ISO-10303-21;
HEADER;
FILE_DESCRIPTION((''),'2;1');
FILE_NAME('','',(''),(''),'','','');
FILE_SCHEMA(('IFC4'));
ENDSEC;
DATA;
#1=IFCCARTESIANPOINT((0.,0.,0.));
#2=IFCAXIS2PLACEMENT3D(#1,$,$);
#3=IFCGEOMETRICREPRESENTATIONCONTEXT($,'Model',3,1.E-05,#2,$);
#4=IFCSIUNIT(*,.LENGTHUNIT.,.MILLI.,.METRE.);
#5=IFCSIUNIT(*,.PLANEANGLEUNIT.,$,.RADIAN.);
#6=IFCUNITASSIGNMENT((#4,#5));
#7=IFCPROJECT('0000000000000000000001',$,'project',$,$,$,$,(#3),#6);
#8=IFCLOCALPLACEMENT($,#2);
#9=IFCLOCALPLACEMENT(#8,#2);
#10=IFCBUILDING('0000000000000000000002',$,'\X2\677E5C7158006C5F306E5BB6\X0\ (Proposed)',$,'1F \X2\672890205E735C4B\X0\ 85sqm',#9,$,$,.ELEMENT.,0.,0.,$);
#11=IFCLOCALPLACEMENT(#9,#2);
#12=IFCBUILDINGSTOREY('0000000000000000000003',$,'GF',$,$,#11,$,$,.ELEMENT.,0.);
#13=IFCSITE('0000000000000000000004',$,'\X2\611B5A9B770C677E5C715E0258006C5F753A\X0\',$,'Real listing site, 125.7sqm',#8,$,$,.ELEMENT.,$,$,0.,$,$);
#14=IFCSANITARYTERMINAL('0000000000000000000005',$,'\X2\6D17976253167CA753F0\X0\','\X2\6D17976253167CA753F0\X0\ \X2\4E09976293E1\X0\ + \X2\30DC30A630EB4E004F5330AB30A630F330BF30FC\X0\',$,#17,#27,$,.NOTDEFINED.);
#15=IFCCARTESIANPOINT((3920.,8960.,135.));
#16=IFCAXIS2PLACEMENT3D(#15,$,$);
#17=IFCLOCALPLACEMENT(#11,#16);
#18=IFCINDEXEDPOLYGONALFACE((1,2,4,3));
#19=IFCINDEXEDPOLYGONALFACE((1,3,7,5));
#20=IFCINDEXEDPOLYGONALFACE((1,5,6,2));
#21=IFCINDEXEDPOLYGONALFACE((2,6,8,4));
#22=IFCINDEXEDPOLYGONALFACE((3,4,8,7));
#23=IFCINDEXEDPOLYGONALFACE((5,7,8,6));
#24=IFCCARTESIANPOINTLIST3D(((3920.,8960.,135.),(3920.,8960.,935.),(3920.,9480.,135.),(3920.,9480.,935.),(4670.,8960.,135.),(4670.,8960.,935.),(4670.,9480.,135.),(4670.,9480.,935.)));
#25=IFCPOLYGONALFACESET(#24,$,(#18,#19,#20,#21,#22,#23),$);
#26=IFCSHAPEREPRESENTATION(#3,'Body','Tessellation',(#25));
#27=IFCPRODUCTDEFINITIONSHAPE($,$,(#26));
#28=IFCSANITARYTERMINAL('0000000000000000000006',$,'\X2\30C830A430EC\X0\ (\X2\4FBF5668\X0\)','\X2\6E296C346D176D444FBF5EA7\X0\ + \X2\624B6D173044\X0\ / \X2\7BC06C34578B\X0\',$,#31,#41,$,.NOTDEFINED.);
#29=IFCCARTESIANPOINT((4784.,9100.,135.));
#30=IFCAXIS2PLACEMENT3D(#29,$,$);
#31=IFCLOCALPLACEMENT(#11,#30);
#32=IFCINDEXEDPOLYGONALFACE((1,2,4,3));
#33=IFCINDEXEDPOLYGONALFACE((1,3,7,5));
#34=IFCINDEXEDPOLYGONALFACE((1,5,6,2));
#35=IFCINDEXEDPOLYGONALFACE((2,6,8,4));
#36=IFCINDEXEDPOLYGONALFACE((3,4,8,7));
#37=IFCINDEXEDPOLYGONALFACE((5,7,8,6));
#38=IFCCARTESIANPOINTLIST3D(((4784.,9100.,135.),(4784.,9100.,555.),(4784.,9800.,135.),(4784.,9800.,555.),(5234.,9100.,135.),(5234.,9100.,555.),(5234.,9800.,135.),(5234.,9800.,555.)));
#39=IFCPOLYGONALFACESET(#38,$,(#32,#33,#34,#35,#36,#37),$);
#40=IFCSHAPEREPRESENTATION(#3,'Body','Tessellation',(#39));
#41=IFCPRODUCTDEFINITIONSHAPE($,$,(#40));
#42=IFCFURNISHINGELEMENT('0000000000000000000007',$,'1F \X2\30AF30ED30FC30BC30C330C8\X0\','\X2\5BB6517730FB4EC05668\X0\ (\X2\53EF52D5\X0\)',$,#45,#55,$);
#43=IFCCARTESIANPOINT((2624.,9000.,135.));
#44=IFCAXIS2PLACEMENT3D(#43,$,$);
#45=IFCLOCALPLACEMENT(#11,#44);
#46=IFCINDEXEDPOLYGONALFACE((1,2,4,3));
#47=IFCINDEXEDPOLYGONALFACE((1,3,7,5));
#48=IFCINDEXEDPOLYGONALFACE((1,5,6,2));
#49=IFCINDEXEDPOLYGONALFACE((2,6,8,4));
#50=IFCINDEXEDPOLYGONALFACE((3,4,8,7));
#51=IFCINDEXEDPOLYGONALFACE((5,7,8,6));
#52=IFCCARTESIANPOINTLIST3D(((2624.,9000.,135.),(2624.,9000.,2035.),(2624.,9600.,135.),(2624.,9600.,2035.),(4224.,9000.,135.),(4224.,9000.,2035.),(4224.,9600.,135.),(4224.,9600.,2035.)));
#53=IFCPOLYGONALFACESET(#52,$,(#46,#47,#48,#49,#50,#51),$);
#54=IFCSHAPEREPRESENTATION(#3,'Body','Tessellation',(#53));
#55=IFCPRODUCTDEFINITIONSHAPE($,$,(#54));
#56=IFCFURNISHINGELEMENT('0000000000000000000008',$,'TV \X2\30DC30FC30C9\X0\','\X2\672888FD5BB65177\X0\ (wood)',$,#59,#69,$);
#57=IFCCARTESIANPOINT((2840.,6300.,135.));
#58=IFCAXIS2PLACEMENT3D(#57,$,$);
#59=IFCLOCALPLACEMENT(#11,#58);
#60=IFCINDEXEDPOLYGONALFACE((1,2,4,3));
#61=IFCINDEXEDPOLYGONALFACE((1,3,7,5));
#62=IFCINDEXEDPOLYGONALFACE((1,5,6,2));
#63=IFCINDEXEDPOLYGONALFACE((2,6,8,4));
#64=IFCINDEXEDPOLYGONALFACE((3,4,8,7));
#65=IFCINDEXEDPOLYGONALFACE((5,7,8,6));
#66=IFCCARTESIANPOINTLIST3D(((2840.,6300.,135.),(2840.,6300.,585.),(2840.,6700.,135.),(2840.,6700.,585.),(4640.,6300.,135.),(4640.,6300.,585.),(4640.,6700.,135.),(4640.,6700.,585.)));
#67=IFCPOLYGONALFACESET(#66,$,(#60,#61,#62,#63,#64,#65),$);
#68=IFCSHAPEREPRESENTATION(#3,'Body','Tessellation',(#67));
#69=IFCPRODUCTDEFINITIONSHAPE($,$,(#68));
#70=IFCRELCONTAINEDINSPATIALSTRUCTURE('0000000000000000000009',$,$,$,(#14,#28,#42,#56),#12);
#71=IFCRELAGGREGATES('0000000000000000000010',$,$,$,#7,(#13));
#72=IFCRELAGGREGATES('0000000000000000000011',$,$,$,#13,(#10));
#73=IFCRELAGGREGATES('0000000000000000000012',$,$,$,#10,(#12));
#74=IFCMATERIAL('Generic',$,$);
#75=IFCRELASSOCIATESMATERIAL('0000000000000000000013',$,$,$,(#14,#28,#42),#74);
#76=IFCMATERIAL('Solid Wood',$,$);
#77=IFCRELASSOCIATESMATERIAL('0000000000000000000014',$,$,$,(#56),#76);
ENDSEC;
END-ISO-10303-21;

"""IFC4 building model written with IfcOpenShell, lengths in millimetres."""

from ifc_helpers import new_model, si_unit, frame, frame_2d, origin, place, context, project, spatial, rectangle, extrude, material, element, save


model = new_model("IFC4")

# Units and contexts
model_context = context("Model", 3, precision=1e-05, world=origin())
ifc_project = project(units=[si_unit("LENGTHUNIT", "METRE", prefix="MILLI"), si_unit("PLANEANGLEUNIT", "RADIAN")], contexts=[model_context])

# Site, building, storey
site_placement = place(None, origin())
site = spatial("IfcSite", under=ifc_project, at=site_placement, Name="愛媛県松山市堀江町", ObjectType="Real listing site, 125.7sqm", CompositionType="ELEMENT", RefElevation=0.0)
building_placement = place(site_placement, origin())
building = spatial("IfcBuilding", under=site, at=building_placement, Name="松山堀江の家 (Proposed)", ObjectType="1F 木造平屋 85sqm", CompositionType="ELEMENT", ElevationOfRefHeight=0.0, ElevationOfTerrain=0.0)
storey_placement = place(building_placement, origin())
storey = spatial("IfcBuildingStorey", under=building, at=storey_placement, Name="GF", CompositionType="ELEMENT", Elevation=0.0)

# Shared definitions
ifc_material_1 = material(Name="Solid Wood")

# Shared definitions
ifc_material_2 = material(Name="Generic")

# Sanitary terminals
sanitary_terminal_1_placement = place(storey_placement, frame((3920.0, 8960.0, 135.0)))
element("IfcSanitaryTerminal", 1, at=sanitary_terminal_1_placement, inside=storey, material=ifc_material_2, Name="洗面化粧台", Description="洗面化粧台 三面鏡 + ボウル一体カウンター", PredefinedType="NOTDEFINED", context=model_context, shape_type="SweptSolid", body=[
    extrude(rectangle(XDim=750.0, YDim=520.0, at=frame_2d((375.0, 260.0))), frame((3920.0, 8960.0, 135.0)), (0.0, 0.0, 1.0), 800.0),
])
sanitary_terminal_2_placement = place(storey_placement, frame((4784.0, 9100.0, 135.0)))
element("IfcSanitaryTerminal", 2, at=sanitary_terminal_2_placement, inside=storey, material=ifc_material_2, Name="トイレ (便器)", Description="温水洗浄便座 + 手洗い / 節水型", PredefinedType="NOTDEFINED", context=model_context, shape_type="SweptSolid", body=[
    extrude(rectangle(XDim=450.0, YDim=700.0, at=frame_2d((225.0, 350.0))), frame((4784.0, 9100.0, 135.0)), (0.0, 0.0, 1.0), 420.0),
])

# Furnishing elements
furnishing_1_placement = place(storey_placement, frame((2624.0, 9000.0, 135.0)))
element("IfcFurnishingElement", 3, at=furnishing_1_placement, inside=storey, material=ifc_material_2, Name="1F クローゼット", Description="家具・什器 (可動)", context=model_context, shape_type="SweptSolid", body=[
    extrude(rectangle(XDim=1600.0, YDim=600.0, at=frame_2d((800.0, 300.0))), frame((2624.0, 9000.0, 135.0)), (0.0, 0.0, 1.0), 1900.0),
])
furnishing_2_placement = place(storey_placement, frame((2840.0, 6300.0, 135.0)))
element("IfcFurnishingElement", 4, at=furnishing_2_placement, inside=storey, material=ifc_material_1, Name="TV ボード", Description="木製家具 (wood)", context=model_context, shape_type="SweptSolid", body=[
    extrude(rectangle(XDim=1800.0, YDim=400.0, at=frame_2d((900.0, 200.0))), frame((2840.0, 6300.0, 135.0)), (0.0, 0.0, 1.0), 450.0),
])

save(model, "model.ifc")
